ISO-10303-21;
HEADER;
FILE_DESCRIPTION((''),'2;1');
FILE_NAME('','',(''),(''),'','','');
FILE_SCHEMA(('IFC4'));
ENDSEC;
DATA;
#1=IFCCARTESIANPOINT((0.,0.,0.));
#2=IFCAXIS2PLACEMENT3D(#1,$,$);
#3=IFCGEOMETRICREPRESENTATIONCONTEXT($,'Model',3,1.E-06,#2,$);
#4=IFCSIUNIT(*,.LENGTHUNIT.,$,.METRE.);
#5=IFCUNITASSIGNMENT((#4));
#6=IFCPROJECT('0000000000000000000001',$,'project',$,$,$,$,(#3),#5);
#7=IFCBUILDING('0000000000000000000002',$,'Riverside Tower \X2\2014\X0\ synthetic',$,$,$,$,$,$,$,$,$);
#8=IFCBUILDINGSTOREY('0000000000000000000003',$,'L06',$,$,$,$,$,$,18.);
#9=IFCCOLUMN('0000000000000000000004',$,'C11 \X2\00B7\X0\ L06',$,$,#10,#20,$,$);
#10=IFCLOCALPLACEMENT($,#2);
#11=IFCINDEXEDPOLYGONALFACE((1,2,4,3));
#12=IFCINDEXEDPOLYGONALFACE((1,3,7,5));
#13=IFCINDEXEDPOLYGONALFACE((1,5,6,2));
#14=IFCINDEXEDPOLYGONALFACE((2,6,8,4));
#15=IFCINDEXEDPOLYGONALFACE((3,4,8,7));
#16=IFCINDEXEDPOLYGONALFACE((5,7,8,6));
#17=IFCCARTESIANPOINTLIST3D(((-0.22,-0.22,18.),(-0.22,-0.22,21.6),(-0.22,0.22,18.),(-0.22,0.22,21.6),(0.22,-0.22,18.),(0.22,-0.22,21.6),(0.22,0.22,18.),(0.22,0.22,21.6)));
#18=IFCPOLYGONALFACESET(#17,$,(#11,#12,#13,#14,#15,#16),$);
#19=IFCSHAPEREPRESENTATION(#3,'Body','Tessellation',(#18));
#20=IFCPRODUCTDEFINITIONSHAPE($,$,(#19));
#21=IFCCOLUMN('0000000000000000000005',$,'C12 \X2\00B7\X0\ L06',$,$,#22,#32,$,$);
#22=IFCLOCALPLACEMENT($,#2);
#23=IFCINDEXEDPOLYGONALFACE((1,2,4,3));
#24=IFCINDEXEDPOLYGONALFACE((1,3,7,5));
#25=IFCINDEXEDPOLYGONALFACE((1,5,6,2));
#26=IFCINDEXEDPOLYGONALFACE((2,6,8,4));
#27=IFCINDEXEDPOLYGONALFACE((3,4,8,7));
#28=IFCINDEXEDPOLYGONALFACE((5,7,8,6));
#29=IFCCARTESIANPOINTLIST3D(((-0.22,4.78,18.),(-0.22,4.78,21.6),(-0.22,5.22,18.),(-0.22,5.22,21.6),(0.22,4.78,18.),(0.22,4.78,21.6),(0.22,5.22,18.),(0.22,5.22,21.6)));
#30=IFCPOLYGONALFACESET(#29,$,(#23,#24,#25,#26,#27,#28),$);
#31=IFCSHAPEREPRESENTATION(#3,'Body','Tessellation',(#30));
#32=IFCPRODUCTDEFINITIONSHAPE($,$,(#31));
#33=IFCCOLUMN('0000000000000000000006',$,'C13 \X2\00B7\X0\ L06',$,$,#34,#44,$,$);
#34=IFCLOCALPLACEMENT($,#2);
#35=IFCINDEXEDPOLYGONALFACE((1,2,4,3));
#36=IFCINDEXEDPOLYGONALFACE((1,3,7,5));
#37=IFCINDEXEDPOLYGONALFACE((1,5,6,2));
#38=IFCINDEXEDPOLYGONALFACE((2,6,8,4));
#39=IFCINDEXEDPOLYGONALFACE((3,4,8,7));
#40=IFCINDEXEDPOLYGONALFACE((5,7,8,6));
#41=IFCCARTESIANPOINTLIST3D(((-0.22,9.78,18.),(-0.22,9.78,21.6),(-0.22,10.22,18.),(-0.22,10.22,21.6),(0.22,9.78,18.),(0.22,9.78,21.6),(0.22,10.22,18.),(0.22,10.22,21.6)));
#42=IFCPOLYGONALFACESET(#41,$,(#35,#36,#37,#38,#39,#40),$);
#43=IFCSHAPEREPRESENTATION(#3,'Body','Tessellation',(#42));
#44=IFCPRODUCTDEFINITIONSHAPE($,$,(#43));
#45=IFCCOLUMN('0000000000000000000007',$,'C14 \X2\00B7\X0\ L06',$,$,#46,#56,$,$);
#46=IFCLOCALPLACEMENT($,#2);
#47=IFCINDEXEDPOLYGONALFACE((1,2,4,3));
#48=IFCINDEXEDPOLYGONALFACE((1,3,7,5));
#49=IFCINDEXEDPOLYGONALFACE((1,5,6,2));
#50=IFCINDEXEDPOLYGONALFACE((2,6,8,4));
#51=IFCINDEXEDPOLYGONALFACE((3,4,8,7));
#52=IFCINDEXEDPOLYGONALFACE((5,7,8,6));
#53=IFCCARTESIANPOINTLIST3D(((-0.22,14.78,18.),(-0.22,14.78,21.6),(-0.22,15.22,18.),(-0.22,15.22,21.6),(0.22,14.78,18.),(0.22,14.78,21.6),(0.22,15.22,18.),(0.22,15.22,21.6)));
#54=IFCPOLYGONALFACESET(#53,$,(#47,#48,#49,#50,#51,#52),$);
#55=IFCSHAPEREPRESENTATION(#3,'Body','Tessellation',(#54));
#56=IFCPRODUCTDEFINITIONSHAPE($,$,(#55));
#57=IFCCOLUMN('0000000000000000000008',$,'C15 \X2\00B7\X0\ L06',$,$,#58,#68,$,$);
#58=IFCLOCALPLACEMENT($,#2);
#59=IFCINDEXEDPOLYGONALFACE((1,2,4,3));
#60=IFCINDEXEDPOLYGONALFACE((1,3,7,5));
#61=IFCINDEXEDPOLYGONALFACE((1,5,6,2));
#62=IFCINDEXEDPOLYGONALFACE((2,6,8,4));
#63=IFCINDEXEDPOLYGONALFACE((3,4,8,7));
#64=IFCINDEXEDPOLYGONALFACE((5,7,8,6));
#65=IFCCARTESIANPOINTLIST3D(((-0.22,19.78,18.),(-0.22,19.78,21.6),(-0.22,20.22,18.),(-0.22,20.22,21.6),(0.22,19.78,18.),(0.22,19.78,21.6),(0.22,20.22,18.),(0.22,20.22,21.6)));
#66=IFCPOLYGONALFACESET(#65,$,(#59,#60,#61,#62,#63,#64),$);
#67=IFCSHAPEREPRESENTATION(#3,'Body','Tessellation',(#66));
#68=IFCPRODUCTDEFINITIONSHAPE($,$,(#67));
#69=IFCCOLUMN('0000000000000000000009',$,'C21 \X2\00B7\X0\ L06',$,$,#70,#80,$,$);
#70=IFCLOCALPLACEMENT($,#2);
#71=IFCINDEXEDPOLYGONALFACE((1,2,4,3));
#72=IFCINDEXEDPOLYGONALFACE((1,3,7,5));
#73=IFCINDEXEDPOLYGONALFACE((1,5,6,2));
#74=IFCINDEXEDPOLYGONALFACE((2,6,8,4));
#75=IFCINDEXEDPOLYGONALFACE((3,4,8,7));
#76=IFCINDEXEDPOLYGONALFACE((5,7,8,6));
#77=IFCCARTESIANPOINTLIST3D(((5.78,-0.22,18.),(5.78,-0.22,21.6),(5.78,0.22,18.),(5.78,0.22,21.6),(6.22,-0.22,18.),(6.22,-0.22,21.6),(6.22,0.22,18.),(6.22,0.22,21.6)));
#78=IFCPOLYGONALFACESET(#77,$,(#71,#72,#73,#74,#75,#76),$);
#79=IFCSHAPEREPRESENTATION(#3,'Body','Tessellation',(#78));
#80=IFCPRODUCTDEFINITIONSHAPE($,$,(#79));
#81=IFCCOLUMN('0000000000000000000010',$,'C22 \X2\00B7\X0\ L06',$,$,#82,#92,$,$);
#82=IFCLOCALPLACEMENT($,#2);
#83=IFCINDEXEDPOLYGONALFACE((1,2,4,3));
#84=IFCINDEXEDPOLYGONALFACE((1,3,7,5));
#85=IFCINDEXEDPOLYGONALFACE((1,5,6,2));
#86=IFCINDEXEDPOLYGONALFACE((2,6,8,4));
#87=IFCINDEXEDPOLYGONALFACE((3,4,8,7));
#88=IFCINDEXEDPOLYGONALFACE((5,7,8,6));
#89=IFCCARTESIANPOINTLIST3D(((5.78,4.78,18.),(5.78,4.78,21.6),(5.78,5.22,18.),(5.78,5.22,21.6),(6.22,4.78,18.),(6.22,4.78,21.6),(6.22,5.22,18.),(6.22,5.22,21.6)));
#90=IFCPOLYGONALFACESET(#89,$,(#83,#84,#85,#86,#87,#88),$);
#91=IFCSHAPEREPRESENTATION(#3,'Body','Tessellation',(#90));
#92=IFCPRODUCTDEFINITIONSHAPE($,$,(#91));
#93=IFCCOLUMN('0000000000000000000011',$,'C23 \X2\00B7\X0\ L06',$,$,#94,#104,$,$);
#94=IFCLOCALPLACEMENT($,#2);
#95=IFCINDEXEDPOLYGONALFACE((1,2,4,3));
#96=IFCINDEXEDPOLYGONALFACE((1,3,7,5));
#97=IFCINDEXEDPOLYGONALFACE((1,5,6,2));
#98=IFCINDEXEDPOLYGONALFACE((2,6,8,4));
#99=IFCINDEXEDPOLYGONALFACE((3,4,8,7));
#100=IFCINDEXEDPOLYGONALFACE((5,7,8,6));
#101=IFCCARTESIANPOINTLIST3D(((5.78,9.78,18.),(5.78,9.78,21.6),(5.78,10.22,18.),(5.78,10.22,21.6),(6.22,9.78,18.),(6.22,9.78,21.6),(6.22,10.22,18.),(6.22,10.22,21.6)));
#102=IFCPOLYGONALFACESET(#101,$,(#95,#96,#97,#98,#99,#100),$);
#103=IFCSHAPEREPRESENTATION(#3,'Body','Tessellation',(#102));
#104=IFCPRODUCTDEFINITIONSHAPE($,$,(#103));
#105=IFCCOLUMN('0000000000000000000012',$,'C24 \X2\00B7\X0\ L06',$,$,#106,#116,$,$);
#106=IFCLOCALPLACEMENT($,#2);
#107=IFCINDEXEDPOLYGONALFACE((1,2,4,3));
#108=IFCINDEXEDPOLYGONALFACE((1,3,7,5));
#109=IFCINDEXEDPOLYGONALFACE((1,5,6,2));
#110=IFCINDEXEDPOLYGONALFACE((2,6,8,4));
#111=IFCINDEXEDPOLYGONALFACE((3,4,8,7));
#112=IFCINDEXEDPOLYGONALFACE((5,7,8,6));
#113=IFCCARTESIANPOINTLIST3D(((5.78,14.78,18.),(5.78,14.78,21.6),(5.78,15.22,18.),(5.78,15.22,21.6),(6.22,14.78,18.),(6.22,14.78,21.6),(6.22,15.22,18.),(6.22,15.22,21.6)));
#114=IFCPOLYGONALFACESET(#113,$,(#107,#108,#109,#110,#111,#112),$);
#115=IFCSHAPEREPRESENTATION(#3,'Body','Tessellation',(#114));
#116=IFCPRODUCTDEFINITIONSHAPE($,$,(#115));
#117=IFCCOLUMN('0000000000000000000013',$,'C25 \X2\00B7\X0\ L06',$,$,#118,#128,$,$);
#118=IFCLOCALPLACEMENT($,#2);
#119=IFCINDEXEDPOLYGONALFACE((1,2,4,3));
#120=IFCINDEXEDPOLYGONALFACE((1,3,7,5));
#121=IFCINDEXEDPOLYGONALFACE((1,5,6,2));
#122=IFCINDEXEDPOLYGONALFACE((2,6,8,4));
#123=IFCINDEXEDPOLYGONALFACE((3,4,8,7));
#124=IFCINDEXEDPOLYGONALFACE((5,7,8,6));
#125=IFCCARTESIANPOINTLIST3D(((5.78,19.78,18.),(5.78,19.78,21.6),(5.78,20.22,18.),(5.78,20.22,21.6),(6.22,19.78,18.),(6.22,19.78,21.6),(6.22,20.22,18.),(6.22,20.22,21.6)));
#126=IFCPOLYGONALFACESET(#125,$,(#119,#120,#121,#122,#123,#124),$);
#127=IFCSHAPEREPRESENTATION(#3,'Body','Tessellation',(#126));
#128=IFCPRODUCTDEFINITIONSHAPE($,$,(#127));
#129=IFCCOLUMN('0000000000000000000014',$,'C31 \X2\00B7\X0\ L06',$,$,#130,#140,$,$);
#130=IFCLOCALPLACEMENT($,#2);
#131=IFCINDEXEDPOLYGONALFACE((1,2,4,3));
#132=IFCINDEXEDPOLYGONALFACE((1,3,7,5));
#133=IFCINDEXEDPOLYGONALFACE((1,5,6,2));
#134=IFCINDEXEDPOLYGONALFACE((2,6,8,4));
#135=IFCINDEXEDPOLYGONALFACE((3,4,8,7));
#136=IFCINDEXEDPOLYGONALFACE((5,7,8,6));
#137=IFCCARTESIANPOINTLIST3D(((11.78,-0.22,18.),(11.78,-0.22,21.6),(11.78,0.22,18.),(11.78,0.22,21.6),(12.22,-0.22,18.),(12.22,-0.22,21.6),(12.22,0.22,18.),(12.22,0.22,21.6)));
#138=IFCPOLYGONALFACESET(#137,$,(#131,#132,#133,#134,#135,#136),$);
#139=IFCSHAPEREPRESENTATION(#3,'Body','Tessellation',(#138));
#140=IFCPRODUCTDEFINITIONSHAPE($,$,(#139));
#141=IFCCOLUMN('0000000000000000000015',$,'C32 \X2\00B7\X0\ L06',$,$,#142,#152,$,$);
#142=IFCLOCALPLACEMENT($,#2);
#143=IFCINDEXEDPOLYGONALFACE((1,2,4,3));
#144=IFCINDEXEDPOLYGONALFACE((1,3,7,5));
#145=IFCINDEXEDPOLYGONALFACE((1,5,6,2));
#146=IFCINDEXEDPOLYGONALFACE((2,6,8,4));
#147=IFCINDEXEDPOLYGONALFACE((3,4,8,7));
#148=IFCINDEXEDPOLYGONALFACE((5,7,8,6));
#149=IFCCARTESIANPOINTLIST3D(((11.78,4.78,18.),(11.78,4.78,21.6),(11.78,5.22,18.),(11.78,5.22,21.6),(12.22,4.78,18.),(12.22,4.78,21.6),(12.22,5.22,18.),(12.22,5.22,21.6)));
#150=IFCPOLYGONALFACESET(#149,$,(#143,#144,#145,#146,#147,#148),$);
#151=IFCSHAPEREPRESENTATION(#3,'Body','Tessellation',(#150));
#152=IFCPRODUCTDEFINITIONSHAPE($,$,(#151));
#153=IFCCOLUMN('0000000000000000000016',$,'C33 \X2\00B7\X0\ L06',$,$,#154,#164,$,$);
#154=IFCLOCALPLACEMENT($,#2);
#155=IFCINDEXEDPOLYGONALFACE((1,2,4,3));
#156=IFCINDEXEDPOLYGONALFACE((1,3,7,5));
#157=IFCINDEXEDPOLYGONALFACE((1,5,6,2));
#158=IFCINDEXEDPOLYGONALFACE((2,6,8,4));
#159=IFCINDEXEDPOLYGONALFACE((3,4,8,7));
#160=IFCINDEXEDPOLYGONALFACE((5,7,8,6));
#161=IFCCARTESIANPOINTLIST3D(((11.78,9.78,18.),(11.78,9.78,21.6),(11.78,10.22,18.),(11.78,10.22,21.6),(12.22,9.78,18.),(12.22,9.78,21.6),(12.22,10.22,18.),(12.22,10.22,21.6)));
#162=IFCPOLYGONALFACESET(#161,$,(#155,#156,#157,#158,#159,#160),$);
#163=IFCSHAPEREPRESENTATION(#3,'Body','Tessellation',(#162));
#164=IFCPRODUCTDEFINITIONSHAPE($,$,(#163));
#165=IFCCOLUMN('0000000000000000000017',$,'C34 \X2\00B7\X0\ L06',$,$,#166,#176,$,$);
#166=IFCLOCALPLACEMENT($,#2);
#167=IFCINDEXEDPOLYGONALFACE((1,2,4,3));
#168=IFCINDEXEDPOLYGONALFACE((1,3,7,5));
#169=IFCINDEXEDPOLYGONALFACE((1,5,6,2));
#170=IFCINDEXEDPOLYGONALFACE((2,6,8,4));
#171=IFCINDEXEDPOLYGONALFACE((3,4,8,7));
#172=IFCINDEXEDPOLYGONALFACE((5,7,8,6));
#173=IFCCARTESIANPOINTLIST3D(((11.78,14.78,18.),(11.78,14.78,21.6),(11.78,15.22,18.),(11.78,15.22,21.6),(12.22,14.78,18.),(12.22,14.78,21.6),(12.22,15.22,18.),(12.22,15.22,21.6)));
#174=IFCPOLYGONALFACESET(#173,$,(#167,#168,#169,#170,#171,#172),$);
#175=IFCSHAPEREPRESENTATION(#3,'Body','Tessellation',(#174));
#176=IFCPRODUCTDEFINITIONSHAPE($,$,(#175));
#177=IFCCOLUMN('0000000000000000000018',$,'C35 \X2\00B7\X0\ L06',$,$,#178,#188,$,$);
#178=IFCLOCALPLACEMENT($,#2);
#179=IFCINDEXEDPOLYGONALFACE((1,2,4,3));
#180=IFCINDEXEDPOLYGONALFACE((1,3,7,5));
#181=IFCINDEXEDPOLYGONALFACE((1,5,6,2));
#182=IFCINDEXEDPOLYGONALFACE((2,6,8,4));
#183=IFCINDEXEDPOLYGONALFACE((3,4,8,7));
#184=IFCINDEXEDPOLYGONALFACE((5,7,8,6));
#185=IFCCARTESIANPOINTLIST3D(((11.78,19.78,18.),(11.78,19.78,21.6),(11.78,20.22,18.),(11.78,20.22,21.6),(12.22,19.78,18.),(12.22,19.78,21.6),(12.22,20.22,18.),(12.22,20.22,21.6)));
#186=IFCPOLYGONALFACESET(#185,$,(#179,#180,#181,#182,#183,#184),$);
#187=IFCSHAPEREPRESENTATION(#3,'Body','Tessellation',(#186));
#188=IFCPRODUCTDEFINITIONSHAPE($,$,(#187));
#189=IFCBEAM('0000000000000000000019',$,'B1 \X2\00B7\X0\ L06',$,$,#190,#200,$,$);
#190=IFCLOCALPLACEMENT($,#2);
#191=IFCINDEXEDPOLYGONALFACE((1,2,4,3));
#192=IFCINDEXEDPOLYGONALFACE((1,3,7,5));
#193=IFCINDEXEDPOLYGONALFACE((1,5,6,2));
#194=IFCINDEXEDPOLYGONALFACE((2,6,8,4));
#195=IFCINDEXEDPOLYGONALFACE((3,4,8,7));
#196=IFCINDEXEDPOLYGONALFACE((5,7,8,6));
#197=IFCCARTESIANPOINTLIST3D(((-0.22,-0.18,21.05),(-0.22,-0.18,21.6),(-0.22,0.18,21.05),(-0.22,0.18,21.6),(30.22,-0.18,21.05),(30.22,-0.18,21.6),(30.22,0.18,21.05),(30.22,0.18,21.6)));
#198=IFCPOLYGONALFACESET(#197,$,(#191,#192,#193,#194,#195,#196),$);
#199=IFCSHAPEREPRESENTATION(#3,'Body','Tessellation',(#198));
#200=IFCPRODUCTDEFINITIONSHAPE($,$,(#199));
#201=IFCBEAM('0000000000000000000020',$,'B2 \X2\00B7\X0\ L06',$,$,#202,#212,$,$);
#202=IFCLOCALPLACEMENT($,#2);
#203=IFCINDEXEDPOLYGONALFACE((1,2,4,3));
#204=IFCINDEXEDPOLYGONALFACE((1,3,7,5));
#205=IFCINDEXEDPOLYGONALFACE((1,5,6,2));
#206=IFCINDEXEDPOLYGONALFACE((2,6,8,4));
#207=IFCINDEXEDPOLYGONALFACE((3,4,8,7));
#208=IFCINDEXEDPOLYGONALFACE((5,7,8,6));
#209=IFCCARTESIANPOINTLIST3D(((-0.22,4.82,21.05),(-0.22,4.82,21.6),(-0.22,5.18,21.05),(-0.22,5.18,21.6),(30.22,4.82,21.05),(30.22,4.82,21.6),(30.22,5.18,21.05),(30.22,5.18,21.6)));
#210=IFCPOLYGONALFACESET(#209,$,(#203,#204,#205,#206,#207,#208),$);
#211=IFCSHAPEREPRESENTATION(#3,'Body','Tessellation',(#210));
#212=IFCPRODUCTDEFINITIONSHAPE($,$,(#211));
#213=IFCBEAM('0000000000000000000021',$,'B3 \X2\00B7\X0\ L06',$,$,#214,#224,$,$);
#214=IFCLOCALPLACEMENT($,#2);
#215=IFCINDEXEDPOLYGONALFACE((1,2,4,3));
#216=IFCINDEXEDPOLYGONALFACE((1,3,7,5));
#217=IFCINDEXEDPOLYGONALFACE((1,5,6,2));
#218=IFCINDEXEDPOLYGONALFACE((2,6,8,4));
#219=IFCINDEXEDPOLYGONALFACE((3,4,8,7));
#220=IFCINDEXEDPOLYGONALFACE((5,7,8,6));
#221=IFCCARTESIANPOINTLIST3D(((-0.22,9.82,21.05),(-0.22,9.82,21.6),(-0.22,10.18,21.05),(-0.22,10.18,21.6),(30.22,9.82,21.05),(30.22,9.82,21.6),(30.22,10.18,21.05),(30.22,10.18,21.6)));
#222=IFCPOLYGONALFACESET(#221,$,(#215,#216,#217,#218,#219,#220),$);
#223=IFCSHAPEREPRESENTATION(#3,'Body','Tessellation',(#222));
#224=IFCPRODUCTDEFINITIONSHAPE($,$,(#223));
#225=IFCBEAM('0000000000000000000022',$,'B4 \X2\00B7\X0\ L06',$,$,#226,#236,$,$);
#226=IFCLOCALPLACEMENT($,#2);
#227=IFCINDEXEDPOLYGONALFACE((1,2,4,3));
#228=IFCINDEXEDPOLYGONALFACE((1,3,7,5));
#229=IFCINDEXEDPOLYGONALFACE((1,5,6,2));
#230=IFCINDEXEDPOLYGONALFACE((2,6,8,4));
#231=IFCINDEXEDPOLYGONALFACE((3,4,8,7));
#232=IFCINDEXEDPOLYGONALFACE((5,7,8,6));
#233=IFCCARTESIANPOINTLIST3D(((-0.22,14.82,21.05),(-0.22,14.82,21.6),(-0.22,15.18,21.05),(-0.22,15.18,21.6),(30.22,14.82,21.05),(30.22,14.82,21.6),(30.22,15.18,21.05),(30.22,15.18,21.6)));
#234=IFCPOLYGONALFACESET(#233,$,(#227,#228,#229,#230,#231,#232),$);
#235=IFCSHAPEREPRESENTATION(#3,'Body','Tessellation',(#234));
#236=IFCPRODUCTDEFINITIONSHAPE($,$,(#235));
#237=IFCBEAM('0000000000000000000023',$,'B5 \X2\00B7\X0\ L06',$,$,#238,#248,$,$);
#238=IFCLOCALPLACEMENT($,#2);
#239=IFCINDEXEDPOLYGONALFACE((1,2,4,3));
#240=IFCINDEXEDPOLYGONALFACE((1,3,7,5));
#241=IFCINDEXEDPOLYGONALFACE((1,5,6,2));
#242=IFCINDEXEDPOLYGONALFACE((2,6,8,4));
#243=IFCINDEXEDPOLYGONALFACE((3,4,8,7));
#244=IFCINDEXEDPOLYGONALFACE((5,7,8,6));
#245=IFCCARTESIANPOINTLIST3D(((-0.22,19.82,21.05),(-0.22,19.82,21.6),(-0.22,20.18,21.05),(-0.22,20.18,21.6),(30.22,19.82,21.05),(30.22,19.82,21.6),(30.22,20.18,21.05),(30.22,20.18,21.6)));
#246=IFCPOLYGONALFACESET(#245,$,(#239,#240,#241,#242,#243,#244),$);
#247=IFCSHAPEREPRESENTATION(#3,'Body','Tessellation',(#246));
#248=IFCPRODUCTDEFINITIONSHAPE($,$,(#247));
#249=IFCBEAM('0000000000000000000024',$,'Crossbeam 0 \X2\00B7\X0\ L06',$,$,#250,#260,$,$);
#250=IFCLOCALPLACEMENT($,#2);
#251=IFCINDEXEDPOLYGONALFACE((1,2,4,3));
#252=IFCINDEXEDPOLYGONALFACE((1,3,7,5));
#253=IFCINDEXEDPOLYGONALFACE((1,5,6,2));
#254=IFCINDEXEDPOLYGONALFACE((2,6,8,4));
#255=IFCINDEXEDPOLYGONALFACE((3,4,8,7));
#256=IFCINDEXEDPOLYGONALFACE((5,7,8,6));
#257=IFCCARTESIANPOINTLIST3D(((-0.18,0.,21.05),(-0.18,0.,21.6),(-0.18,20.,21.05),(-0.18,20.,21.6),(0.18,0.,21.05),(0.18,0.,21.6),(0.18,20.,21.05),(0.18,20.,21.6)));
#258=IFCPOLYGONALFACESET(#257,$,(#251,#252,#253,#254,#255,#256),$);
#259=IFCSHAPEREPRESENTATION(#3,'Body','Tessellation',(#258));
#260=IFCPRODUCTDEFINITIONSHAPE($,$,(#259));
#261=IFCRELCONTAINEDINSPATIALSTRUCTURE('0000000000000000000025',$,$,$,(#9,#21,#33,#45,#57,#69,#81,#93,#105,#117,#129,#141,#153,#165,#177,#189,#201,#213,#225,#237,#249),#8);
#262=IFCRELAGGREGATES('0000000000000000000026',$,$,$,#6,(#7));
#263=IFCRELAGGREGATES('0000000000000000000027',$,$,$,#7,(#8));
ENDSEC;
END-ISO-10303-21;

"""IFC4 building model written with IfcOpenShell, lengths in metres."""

from ifc_helpers import new_model, si_unit, frame, origin, place, context, project, spatial, rectangle, extrude, element, save


model = new_model("IFC4")

# Units and contexts
model_context = context("Model", 3, precision=1e-06, world=origin())
ifc_project = project(units=[si_unit("LENGTHUNIT", "METRE")], contexts=[model_context])

# Building, storey
building = spatial("IfcBuilding", under=ifc_project, Name="Riverside Tower — synthetic")
storey = spatial("IfcBuildingStorey", under=building, Name="L06", Elevation=18.0)

# Columns
for number, where, name in (
    (1, (0.0, 0.0, 18.0), "C11 · L06"),
    (2, (0.0, 5.0, 18.0), "C12 · L06"),
    (3, (0.0, 10.0, 18.0), "C13 · L06"),
    (4, (0.0, 15.0, 18.0), "C14 · L06"),
    (5, (0.0, 20.0, 18.0), "C15 · L06"),
    (6, (6.0, 0.0, 18.0), "C21 · L06"),
    (7, (6.0, 5.0, 18.0), "C22 · L06"),
    (8, (6.0, 10.0, 18.0), "C23 · L06"),
    (9, (6.0, 15.0, 18.0), "C24 · L06"),
    (10, (6.0, 20.0, 18.0), "C25 · L06"),
    (11, (12.0, 0.0, 18.0), "C31 · L06"),
    (12, (12.0, 5.0, 18.0), "C32 · L06"),
    (13, (12.0, 10.0, 18.0), "C33 · L06"),
    (14, (12.0, 15.0, 18.0), "C34 · L06"),
    (15, (12.0, 20.0, 18.0), "C35 · L06"),
):
    element("IfcColumn", number, at=place(None, frame(where)), inside=storey, Name=name, context=model_context, shape_type="SweptSolid", body=[
        extrude(rectangle(XDim=0.44, YDim=0.44), origin(), (0.0, 0.0, 1.0), 3.6),
    ])

# Beams
for number, where, name in (
    (16, (15.0, 0.0, 21.05), "B1 · L06"),
    (17, (15.0, 5.0, 21.05), "B2 · L06"),
    (18, (15.0, 10.0, 21.05), "B3 · L06"),
    (19, (15.0, 15.0, 21.05), "B4 · L06"),
    (20, (15.0, 20.0, 21.05), "B5 · L06"),
):
    element("IfcBeam", number, at=place(None, frame(where)), inside=storey, Name=name, context=model_context, shape_type="SweptSolid", body=[
        extrude(rectangle(XDim=30.44, YDim=0.36), origin(), (0.0, 0.0, 1.0), 0.55),
    ])
for number, where, name in (
    (21, (0.0, 10.0, 21.05), "Crossbeam 0 · L06"),
):
    element("IfcBeam", number, at=place(None, frame(where)), inside=storey, Name=name, context=model_context, shape_type="SweptSolid", body=[
        extrude(rectangle(XDim=0.36, YDim=20.0), origin(), (0.0, 0.0, 1.0), 0.55),
    ])

save(model, "model.ifc")
